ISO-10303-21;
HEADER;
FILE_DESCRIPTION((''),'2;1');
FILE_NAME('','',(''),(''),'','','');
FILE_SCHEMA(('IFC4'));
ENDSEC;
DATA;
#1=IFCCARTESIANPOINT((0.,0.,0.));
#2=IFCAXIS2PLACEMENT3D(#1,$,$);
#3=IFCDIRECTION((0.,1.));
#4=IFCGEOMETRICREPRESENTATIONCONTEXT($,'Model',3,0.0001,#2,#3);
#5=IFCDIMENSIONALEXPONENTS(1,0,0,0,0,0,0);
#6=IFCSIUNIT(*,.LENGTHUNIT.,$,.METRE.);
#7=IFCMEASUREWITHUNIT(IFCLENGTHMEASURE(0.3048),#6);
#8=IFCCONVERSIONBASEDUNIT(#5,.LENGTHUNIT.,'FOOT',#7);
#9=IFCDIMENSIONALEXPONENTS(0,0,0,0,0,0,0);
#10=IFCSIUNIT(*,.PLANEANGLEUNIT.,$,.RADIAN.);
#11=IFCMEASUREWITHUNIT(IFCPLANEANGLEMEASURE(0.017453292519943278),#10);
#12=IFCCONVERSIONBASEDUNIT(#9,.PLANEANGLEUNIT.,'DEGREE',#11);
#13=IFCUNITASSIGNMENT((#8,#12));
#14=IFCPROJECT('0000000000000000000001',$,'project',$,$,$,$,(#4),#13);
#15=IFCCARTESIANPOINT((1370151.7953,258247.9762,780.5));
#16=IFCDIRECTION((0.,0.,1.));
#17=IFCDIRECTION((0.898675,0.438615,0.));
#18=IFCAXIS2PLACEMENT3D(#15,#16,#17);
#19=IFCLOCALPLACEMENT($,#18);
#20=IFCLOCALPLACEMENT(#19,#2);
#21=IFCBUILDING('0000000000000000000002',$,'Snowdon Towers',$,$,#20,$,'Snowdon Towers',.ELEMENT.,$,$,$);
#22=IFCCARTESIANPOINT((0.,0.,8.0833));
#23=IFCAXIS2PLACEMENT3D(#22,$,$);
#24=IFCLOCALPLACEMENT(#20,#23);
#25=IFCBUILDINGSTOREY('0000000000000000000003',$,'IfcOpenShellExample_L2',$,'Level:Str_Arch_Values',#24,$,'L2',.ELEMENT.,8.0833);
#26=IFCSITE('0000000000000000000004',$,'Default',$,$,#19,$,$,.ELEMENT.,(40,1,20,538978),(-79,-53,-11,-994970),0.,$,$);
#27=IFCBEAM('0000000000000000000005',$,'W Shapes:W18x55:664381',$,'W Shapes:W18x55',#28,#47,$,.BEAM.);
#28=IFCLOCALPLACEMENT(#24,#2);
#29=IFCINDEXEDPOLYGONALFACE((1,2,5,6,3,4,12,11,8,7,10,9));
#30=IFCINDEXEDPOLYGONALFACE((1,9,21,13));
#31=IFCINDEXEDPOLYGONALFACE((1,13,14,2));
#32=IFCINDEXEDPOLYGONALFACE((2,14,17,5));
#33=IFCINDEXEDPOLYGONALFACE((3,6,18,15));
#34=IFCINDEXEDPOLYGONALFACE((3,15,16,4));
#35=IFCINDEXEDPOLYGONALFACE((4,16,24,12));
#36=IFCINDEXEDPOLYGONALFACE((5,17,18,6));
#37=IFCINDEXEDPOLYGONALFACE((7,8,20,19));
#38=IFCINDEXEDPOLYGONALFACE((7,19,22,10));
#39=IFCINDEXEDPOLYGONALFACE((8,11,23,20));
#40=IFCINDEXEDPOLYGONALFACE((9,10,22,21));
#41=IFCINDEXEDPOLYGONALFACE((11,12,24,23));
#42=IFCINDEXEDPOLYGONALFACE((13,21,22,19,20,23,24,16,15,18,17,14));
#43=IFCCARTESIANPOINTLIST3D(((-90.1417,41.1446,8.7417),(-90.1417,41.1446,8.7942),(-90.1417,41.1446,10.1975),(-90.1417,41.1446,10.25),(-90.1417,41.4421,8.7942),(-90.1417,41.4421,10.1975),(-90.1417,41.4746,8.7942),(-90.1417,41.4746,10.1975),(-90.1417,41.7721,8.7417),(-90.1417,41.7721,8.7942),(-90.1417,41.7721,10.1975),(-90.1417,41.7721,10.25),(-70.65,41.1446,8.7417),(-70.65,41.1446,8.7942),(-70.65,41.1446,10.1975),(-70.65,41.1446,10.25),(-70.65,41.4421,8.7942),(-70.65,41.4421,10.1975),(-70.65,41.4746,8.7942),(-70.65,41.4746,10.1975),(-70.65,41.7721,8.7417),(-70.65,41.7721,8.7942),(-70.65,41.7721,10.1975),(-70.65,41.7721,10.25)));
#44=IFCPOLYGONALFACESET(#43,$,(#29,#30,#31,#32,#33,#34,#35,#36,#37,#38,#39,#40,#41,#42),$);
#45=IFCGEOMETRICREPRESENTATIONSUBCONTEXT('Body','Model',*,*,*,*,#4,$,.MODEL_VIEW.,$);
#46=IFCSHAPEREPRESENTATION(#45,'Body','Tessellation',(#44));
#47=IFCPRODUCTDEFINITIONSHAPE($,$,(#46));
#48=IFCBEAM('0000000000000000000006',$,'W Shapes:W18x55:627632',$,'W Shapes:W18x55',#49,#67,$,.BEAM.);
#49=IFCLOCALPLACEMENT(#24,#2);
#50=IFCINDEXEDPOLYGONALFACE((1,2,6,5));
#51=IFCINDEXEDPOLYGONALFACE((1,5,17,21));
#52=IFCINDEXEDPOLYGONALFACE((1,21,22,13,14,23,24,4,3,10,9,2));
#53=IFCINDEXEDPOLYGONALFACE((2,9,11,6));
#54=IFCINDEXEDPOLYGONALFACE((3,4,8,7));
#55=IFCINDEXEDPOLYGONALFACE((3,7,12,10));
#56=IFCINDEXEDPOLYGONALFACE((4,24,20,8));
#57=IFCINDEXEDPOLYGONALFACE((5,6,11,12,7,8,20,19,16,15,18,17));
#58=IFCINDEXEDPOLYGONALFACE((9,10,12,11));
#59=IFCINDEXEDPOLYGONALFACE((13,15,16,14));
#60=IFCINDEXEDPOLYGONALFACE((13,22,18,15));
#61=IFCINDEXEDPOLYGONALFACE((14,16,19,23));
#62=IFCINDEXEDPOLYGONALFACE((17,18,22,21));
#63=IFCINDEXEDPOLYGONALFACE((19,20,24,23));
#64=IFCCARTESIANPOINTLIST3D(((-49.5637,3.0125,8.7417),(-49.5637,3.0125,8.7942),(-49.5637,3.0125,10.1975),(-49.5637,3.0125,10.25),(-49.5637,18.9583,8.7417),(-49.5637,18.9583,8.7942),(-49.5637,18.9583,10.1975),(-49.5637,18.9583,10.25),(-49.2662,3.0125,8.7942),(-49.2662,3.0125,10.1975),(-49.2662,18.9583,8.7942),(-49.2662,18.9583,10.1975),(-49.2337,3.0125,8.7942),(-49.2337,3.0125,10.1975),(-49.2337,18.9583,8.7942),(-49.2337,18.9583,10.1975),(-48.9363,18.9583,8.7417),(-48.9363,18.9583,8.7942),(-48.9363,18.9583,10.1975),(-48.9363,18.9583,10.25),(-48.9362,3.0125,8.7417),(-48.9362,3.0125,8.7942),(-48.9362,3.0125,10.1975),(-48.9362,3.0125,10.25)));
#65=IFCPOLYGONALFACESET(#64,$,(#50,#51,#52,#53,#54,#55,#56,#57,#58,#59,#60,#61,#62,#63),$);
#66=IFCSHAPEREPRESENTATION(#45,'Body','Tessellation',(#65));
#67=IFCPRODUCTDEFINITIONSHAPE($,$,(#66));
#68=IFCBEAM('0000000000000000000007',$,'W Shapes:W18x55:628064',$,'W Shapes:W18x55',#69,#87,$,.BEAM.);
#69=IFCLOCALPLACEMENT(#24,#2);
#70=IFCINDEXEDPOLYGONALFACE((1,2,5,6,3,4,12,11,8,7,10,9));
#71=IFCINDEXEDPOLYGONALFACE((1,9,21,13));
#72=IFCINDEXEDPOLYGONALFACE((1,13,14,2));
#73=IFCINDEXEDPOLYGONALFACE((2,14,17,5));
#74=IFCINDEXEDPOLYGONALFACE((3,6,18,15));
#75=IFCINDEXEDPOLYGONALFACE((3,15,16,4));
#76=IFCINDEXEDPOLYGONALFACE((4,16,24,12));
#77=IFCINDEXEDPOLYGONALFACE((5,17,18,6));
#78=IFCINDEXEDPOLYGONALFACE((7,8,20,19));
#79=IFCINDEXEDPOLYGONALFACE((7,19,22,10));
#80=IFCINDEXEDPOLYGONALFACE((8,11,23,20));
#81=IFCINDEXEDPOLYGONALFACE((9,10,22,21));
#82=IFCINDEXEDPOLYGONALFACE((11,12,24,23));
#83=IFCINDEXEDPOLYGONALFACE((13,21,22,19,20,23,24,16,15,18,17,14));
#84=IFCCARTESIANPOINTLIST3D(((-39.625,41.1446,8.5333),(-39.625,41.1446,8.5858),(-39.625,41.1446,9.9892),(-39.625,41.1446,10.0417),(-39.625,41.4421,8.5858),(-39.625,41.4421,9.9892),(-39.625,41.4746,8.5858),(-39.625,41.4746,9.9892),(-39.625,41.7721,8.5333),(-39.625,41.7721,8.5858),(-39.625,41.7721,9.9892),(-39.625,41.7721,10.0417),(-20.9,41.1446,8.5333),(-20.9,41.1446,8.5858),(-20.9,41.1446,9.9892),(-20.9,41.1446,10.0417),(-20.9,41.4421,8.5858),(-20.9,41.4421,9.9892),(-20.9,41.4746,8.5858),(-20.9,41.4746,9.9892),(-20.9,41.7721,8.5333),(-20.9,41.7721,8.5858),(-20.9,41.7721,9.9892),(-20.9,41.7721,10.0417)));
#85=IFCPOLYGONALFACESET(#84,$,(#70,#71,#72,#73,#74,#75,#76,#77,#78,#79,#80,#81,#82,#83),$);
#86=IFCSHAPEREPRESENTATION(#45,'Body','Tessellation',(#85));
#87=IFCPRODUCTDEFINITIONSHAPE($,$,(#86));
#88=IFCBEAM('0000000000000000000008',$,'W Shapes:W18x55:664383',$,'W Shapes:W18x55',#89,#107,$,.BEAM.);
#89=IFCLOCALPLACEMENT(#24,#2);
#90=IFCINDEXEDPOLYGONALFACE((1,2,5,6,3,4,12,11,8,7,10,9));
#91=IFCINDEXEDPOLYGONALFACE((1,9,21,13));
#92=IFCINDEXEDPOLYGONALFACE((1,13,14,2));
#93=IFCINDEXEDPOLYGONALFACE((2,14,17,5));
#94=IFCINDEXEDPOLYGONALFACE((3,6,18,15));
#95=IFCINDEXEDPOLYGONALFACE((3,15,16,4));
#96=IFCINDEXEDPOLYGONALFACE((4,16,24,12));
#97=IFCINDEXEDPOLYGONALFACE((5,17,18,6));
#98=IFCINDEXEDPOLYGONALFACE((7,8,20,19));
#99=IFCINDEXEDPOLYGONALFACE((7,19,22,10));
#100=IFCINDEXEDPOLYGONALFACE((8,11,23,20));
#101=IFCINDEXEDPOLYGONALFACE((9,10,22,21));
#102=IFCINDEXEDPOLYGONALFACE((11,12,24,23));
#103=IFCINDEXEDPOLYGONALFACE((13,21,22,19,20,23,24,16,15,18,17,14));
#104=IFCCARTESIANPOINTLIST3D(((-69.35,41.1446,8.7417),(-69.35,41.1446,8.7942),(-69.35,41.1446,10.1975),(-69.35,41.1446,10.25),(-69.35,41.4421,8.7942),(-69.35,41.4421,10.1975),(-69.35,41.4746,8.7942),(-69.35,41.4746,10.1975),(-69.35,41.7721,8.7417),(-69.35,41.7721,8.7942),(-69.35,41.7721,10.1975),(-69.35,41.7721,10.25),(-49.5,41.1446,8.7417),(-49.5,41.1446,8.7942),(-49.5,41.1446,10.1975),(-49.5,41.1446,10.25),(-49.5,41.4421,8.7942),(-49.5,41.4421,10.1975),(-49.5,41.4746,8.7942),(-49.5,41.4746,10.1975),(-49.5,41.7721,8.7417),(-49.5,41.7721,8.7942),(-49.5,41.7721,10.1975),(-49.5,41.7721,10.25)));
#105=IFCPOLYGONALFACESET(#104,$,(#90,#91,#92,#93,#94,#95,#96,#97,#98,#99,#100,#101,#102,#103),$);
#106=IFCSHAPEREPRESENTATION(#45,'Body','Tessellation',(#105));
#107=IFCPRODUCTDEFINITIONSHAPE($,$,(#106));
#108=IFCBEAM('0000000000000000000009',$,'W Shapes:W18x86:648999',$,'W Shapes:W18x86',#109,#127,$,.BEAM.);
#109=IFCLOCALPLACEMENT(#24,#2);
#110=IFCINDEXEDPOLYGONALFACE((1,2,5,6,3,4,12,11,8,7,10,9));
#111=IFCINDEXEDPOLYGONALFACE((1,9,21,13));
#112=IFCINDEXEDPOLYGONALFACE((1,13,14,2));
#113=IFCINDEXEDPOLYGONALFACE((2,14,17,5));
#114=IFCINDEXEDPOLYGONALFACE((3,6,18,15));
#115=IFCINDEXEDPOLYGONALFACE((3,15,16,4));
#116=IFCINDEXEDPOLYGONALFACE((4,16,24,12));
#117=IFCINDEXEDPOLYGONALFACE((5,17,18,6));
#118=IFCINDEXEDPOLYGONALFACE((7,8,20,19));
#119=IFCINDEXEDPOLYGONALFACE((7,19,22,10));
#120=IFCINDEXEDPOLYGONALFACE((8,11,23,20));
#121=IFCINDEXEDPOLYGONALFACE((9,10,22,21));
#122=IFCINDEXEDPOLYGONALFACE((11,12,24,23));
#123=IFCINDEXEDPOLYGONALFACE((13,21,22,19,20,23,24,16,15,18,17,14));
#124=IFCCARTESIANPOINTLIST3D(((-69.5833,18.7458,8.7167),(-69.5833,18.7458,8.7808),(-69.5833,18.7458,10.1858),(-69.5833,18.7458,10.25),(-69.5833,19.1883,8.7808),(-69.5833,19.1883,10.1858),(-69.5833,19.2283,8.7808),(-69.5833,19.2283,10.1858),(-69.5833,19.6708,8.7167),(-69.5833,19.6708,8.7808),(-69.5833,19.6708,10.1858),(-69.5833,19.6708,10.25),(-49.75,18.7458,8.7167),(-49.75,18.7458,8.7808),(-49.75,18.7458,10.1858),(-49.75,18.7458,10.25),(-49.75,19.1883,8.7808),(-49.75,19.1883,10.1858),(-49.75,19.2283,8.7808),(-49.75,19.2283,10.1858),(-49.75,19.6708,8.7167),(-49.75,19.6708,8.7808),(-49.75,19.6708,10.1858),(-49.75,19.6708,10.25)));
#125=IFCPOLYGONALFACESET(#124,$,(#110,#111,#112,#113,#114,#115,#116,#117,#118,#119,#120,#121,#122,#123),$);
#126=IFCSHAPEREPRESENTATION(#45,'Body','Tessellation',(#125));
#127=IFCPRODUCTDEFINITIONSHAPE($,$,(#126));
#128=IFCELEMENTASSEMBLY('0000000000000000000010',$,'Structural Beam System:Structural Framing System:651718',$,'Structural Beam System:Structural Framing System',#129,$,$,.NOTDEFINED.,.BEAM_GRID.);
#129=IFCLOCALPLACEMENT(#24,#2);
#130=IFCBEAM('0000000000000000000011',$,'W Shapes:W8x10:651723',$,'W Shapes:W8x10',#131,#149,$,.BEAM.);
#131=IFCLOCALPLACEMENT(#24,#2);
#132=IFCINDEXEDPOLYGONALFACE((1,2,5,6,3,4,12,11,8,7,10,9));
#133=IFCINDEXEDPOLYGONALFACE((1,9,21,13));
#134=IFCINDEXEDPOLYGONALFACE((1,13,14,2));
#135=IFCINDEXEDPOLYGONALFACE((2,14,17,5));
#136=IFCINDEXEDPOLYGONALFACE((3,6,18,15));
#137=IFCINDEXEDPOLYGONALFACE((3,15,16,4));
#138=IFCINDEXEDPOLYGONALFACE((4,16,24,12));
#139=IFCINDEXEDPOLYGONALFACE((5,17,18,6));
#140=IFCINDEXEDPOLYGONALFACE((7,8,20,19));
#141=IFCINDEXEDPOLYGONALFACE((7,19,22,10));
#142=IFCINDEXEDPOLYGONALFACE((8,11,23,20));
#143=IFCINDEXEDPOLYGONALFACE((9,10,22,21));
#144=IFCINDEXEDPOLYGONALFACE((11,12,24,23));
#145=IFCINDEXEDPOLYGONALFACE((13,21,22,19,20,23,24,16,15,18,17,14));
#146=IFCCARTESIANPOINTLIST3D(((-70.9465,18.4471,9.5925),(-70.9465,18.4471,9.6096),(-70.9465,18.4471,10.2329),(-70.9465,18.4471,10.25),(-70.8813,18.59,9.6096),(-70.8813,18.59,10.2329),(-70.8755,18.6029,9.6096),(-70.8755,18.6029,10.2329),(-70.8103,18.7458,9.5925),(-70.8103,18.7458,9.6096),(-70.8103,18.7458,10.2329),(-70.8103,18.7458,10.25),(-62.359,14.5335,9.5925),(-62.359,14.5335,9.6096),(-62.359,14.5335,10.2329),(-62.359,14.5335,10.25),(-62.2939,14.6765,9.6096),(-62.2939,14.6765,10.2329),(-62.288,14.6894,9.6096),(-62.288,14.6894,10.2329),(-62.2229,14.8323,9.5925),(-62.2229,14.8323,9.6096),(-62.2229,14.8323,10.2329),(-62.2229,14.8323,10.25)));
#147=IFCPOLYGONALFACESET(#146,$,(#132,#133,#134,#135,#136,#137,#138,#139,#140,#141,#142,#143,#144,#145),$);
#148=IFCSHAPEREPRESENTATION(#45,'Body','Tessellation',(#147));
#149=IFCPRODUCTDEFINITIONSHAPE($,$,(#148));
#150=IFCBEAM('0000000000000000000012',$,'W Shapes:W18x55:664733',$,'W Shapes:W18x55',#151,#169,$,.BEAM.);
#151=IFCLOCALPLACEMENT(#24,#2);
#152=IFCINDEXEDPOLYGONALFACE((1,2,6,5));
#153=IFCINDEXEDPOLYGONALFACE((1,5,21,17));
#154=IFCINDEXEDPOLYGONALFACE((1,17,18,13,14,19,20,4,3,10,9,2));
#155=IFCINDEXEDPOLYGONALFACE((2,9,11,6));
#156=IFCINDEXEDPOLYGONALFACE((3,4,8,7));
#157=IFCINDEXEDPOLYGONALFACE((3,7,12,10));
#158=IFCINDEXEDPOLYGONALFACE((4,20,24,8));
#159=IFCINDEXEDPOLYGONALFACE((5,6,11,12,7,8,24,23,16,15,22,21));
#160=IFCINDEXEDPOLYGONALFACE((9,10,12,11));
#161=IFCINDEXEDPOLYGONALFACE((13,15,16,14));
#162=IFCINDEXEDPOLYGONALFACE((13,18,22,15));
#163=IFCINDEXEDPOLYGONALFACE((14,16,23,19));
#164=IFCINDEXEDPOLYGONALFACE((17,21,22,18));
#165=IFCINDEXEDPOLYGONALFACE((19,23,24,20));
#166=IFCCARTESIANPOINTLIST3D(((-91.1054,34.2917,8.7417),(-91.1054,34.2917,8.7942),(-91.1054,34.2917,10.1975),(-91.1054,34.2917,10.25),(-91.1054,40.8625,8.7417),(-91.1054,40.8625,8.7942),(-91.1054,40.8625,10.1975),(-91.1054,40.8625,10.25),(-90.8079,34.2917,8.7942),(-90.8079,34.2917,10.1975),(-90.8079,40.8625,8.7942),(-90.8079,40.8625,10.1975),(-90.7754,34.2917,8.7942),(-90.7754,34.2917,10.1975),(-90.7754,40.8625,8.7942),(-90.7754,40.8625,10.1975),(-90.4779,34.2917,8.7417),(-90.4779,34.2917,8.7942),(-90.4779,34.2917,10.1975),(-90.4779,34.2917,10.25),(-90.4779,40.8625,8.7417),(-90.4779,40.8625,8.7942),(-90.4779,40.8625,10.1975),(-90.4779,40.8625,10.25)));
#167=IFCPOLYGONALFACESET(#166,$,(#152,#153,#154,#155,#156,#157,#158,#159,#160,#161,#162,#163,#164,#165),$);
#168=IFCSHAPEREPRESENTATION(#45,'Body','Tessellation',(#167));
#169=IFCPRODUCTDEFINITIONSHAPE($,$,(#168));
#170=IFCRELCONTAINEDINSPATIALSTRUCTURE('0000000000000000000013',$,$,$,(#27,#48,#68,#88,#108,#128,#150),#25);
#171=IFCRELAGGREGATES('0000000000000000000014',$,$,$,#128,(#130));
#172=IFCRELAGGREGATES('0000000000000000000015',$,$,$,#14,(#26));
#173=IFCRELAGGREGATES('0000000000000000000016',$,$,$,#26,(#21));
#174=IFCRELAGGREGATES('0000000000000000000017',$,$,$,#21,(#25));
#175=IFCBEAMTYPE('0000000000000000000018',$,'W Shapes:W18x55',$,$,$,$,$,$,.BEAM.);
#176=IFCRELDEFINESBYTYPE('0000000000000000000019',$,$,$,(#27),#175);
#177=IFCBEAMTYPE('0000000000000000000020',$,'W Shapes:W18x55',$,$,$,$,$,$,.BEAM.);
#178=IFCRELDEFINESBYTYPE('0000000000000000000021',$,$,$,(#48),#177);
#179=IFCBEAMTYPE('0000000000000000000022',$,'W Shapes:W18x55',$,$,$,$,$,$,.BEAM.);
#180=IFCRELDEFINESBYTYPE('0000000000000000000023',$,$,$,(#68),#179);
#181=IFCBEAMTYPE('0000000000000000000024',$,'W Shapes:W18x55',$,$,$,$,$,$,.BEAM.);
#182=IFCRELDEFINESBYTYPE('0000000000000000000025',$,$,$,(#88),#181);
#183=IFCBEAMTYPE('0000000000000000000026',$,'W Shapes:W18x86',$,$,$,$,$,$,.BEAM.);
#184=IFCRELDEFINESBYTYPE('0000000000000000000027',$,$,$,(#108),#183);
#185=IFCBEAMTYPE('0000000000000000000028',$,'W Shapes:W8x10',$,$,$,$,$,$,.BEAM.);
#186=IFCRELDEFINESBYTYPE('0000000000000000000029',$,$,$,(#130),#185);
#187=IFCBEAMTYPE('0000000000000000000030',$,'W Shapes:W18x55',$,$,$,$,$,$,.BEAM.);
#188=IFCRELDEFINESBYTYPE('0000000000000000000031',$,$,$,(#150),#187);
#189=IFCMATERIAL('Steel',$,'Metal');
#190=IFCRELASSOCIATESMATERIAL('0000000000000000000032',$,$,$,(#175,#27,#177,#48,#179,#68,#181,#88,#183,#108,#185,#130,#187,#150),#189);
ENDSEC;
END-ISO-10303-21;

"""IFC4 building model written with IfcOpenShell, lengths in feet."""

from ifc_helpers import new_model, entity, si_unit, converted_unit, direction, frame, origin, place, context, subcontext, project, spatial, indexed_curve, outline, extrude, source, transform, mapped, material, type_object, type_shapes, element, aggregate, save


model = new_model("IFC4")

# Units and contexts
model_context = context("Model", 3, precision=0.0001, world=origin(), true_north=direction((0.0, 1.0)))
body_context = subcontext(model_context, "Body", "Model", "MODEL_VIEW")
ifc_project = project(units=[converted_unit("LENGTHUNIT", "FOOT", entity("IfcLengthMeasure", 0.3048), si_unit("LENGTHUNIT", "METRE"), dimensions=[1, 0, 0, 0, 0, 0, 0]), converted_unit("PLANEANGLEUNIT", "DEGREE", entity("IfcPlaneAngleMeasure", 0.017453292519943278), si_unit("PLANEANGLEUNIT", "RADIAN"), dimensions=[0, 0, 0, 0, 0, 0, 0])], contexts=[model_context])

# Site, building, storey
site_placement = place(None, frame((1370151.7953, 258247.9762, 780.5), z_axis=(0.0, 0.0, 1.0), x_axis=(0.898675, 0.438615, 0.0)))
site = spatial("IfcSite", under=ifc_project, at=site_placement, Name="Default", CompositionType="ELEMENT", RefLatitude=(40, 1, 20, 538978), RefLongitude=(-79, -53, -11, -994970), RefElevation=0.0)
building_placement = place(site_placement, origin())
building = spatial("IfcBuilding", under=site, at=building_placement, Name="Snowdon Towers", LongName="Snowdon Towers", CompositionType="ELEMENT")
storey_placement = place(building_placement, frame((0.0, 0.0, 8.0833)))
storey = spatial("IfcBuildingStorey", under=building, at=storey_placement, Name="IfcOpenShellExample_L2", ObjectType="Level:Str_Arch_Values", LongName="L2", CompositionType="ELEMENT", Elevation=8.0833)

# Shared definitions
ifc_material = material(Name="Steel", Category="Metal")

# Beams
beam_type_1 = type_object("IfcBeamType", Name="W Shapes:W18x55", PredefinedType="BEAM", material=ifc_material)
shared_shape_1 = source(origin(), body_context, "Body", "SweptSolid", [
    extrude(outline(indexed_curve([(-0.3138, -0.7017), (-0.3138, -0.7542), (0.3138, -0.7542), (0.3138, -0.7017), (0.0162, -0.7017), (0.0162, 0.7017), (0.3138, 0.7017), (0.3138, 0.7542), (-0.3137, 0.7542), (-0.3137, 0.7017), (-0.0163, 0.7017), (-0.0163, -0.7017), (-0.3138, -0.7017)], self_intersect=False)), frame((-9.7875, 0.0, 0.0), z_axis=(-1.0, 0.0, 0.0), x_axis=(0.0, -1.0, 0.0)), (0.0, 0.0, -1.0), 19.4917),
])
type_shapes(beam_type_1, [shared_shape_1])
beam_1_placement = place(storey_placement, frame((-80.3542, 41.4583, 9.4958)))
element("IfcBeam", 1, at=beam_1_placement, inside=storey, type_object=beam_type_1, material=ifc_material, Name="W Shapes:W18x55:664381", ObjectType="W Shapes:W18x55", PredefinedType="BEAM", context=body_context, shape_type="MappedRepresentation", body=[
    mapped(shared_shape_1, transform((0.0, 0.0, 0.0), scale=1.0)),
])
beam_type_2 = type_object("IfcBeamType", Name="W Shapes:W18x55", PredefinedType="BEAM", material=ifc_material)
shared_shape_2 = source(origin(), body_context, "Body", "SweptSolid", [
    extrude(outline(indexed_curve([(-0.3138, -0.7017), (-0.3138, -0.7542), (0.3138, -0.7542), (0.3138, -0.7017), (0.0162, -0.7017), (0.0162, 0.7017), (0.3138, 0.7017), (0.3138, 0.7542), (-0.3137, 0.7542), (-0.3137, 0.7017), (-0.0163, 0.7017), (-0.0163, -0.7017), (-0.3138, -0.7017)], self_intersect=False)), frame((-8.1042, 0.0, 0.0), z_axis=(-1.0, 0.0, 0.0), x_axis=(0.0, -1.0, 0.0)), (0.0, 0.0, -1.0), 15.9458),
])
type_shapes(beam_type_2, [shared_shape_2])
beam_2_placement = place(storey_placement, frame((-49.25, 10.8542, 9.4958), z_axis=(0.0, 0.0, 1.0), x_axis=(0.0, -1.0, 0.0)))
element("IfcBeam", 2, at=beam_2_placement, inside=storey, type_object=beam_type_2, material=ifc_material, Name="W Shapes:W18x55:627632", ObjectType="W Shapes:W18x55", PredefinedType="BEAM", context=body_context, shape_type="MappedRepresentation", body=[
    mapped(shared_shape_2, transform((0.0, 0.0, 0.0), scale=1.0)),
])
beam_type_3 = type_object("IfcBeamType", Name="W Shapes:W18x55", PredefinedType="BEAM", material=ifc_material)
shared_shape_3 = source(origin(), body_context, "Body", "SweptSolid", [
    extrude(outline(indexed_curve([(-0.3138, -0.7017), (-0.3138, -0.7542), (0.3138, -0.7542), (0.3138, -0.7017), (0.0162, -0.7017), (0.0162, 0.7017), (0.3138, 0.7017), (0.3138, 0.7542), (-0.3137, 0.7542), (-0.3137, 0.7017), (-0.0163, 0.7017), (-0.0163, -0.7017), (-0.3138, -0.7017)], self_intersect=False)), frame((-9.5625, 0.0, 0.0), z_axis=(-1.0, 0.0, 0.0), x_axis=(0.0, -1.0, 0.0)), (0.0, 0.0, -1.0), 18.725),
])
type_shapes(beam_type_3, [shared_shape_3])
beam_3_placement = place(storey_placement, frame((-30.0625, 41.4583, 9.2875)))
element("IfcBeam", 3, at=beam_3_placement, inside=storey, type_object=beam_type_3, material=ifc_material, Name="W Shapes:W18x55:628064", ObjectType="W Shapes:W18x55", PredefinedType="BEAM", context=body_context, shape_type="MappedRepresentation", body=[
    mapped(shared_shape_3, transform((0.0, 0.0, 0.0), scale=1.0)),
])
beam_type_4 = type_object("IfcBeamType", Name="W Shapes:W18x55", PredefinedType="BEAM", material=ifc_material)
shared_shape_4 = source(origin(), body_context, "Body", "SweptSolid", [
    extrude(outline(indexed_curve([(-0.3138, -0.7017), (-0.3138, -0.7542), (0.3138, -0.7542), (0.3138, -0.7017), (0.0162, -0.7017), (0.0162, 0.7017), (0.3138, 0.7017), (0.3138, 0.7542), (-0.3137, 0.7542), (-0.3137, 0.7017), (-0.0163, 0.7017), (-0.0163, -0.7017), (-0.3138, -0.7017)], self_intersect=False)), frame((-9.725, 0.0, 0.0), z_axis=(-1.0, 0.0, 0.0), x_axis=(0.0, -1.0, 0.0)), (0.0, 0.0, -1.0), 19.85),
])
type_shapes(beam_type_4, [shared_shape_4])
beam_4_placement = place(storey_placement, frame((-59.625, 41.4583, 9.4958)))
element("IfcBeam", 4, at=beam_4_placement, inside=storey, type_object=beam_type_4, material=ifc_material, Name="W Shapes:W18x55:664383", ObjectType="W Shapes:W18x55", PredefinedType="BEAM", context=body_context, shape_type="MappedRepresentation", body=[
    mapped(shared_shape_4, transform((0.0, 0.0, 0.0), scale=1.0)),
])
beam_type_5 = type_object("IfcBeamType", Name="W Shapes:W18x86", PredefinedType="BEAM", material=ifc_material)
shared_shape_5 = source(origin(), body_context, "Body", "SweptSolid", [
    extrude(outline(indexed_curve([(-0.4625, -0.7025), (-0.4625, -0.7667), (0.4625, -0.7667), (0.4625, -0.7025), (0.02, -0.7025), (0.02, 0.7025), (0.4625, 0.7025), (0.4625, 0.7667), (-0.4625, 0.7667), (-0.4625, 0.7025), (-0.02, 0.7025), (-0.02, -0.7025), (-0.4625, -0.7025)], self_intersect=False)), frame((-9.9583, 0.0, 0.0), z_axis=(-1.0, 0.0, 0.0), x_axis=(0.0, -1.0, 0.0)), (0.0, 0.0, -1.0), 19.8333),
])
type_shapes(beam_type_5, [shared_shape_5])
beam_5_placement = place(storey_placement, frame((-59.625, 19.2083, 9.4833)))
element("IfcBeam", 5, at=beam_5_placement, inside=storey, type_object=beam_type_5, material=ifc_material, Name="W Shapes:W18x86:648999", ObjectType="W Shapes:W18x86", PredefinedType="BEAM", context=body_context, shape_type="MappedRepresentation", body=[
    mapped(shared_shape_5, transform((0.0, 0.0, 0.0), scale=1.0)),
])

# Element assembly, beam
assembly_1_placement = place(storey_placement, origin())
assembly_1 = element("IfcElementAssembly", 6, at=assembly_1_placement, inside=storey, Name="Structural Beam System:Structural Framing System:651718", ObjectType="Structural Beam System:Structural Framing System", AssemblyPlace="NOTDEFINED", PredefinedType="BEAM_GRID")
beam_type_6 = type_object("IfcBeamType", Name="W Shapes:W8x10", PredefinedType="BEAM", material=ifc_material)
shared_shape_6 = source(origin(), body_context, "Body", "SweptSolid", [
    extrude(outline(indexed_curve([(-0.1642, -0.3117), (-0.1642, -0.3288), (0.1642, -0.3288), (0.1642, -0.3117), (0.0071, -0.3117), (0.0071, 0.3117), (0.1642, 0.3117), (0.1642, 0.3287), (-0.1642, 0.3287), (-0.1642, 0.3117), (-0.0071, 0.3117), (-0.0071, -0.3117), (-0.1642, -0.3117)], self_intersect=False)), frame((-4.2121, 0.0, 0.0), z_axis=(-1.0, 0.0, 0.0), x_axis=(0.0, -1.0, 0.0)), (0.0, 0.0, -1.0), 9.4371),
])
type_shapes(beam_type_6, [shared_shape_6])
beam_6_placement = place(assembly_1_placement, frame((-67.0456, 16.8497, 9.9213), z_axis=(0.0, 0.0, 1.0), x_axis=(0.909961, -0.414693, 0.0)))
beam_6 = element("IfcBeam", 7, at=beam_6_placement, type_object=beam_type_6, material=ifc_material, Name="W Shapes:W8x10:651723", ObjectType="W Shapes:W8x10", PredefinedType="BEAM", context=body_context, shape_type="MappedRepresentation", body=[
    mapped(shared_shape_6, transform((0.0, 0.0, 0.0), scale=1.0)),
])
aggregate(assembly_1, [beam_6])

# Beam
beam_type_7 = type_object("IfcBeamType", Name="W Shapes:W18x55", PredefinedType="BEAM", material=ifc_material)
shared_shape_7 = source(origin(), body_context, "Body", "SweptSolid", [
    extrude(outline(indexed_curve([(-0.3138, -0.7017), (-0.3138, -0.7542), (0.3138, -0.7542), (0.3138, -0.7017), (0.0162, -0.7017), (0.0162, 0.7017), (0.3138, 0.7017), (0.3138, 0.7542), (-0.3137, 0.7542), (-0.3137, 0.7017), (-0.0163, 0.7017), (-0.0163, -0.7017), (-0.3138, -0.7017)], self_intersect=False)), frame((-3.1958, 0.0, 0.0), z_axis=(-1.0, 0.0, 0.0), x_axis=(0.0, -1.0, 0.0)), (0.0, 0.0, -1.0), 6.5708),
])
type_shapes(beam_type_7, [shared_shape_7])
beam_7_placement = place(storey_placement, frame((-90.7917, 37.6667, 9.4958), z_axis=(0.0, 0.0, 1.0), x_axis=(0.0, -1.0, 0.0)))
element("IfcBeam", 8, at=beam_7_placement, inside=storey, type_object=beam_type_7, material=ifc_material, Name="W Shapes:W18x55:664733", ObjectType="W Shapes:W18x55", PredefinedType="BEAM", context=body_context, shape_type="MappedRepresentation", body=[
    mapped(shared_shape_7, transform((0.0, 0.0, 0.0), scale=1.0)),
])

save(model, "model.ifc")
